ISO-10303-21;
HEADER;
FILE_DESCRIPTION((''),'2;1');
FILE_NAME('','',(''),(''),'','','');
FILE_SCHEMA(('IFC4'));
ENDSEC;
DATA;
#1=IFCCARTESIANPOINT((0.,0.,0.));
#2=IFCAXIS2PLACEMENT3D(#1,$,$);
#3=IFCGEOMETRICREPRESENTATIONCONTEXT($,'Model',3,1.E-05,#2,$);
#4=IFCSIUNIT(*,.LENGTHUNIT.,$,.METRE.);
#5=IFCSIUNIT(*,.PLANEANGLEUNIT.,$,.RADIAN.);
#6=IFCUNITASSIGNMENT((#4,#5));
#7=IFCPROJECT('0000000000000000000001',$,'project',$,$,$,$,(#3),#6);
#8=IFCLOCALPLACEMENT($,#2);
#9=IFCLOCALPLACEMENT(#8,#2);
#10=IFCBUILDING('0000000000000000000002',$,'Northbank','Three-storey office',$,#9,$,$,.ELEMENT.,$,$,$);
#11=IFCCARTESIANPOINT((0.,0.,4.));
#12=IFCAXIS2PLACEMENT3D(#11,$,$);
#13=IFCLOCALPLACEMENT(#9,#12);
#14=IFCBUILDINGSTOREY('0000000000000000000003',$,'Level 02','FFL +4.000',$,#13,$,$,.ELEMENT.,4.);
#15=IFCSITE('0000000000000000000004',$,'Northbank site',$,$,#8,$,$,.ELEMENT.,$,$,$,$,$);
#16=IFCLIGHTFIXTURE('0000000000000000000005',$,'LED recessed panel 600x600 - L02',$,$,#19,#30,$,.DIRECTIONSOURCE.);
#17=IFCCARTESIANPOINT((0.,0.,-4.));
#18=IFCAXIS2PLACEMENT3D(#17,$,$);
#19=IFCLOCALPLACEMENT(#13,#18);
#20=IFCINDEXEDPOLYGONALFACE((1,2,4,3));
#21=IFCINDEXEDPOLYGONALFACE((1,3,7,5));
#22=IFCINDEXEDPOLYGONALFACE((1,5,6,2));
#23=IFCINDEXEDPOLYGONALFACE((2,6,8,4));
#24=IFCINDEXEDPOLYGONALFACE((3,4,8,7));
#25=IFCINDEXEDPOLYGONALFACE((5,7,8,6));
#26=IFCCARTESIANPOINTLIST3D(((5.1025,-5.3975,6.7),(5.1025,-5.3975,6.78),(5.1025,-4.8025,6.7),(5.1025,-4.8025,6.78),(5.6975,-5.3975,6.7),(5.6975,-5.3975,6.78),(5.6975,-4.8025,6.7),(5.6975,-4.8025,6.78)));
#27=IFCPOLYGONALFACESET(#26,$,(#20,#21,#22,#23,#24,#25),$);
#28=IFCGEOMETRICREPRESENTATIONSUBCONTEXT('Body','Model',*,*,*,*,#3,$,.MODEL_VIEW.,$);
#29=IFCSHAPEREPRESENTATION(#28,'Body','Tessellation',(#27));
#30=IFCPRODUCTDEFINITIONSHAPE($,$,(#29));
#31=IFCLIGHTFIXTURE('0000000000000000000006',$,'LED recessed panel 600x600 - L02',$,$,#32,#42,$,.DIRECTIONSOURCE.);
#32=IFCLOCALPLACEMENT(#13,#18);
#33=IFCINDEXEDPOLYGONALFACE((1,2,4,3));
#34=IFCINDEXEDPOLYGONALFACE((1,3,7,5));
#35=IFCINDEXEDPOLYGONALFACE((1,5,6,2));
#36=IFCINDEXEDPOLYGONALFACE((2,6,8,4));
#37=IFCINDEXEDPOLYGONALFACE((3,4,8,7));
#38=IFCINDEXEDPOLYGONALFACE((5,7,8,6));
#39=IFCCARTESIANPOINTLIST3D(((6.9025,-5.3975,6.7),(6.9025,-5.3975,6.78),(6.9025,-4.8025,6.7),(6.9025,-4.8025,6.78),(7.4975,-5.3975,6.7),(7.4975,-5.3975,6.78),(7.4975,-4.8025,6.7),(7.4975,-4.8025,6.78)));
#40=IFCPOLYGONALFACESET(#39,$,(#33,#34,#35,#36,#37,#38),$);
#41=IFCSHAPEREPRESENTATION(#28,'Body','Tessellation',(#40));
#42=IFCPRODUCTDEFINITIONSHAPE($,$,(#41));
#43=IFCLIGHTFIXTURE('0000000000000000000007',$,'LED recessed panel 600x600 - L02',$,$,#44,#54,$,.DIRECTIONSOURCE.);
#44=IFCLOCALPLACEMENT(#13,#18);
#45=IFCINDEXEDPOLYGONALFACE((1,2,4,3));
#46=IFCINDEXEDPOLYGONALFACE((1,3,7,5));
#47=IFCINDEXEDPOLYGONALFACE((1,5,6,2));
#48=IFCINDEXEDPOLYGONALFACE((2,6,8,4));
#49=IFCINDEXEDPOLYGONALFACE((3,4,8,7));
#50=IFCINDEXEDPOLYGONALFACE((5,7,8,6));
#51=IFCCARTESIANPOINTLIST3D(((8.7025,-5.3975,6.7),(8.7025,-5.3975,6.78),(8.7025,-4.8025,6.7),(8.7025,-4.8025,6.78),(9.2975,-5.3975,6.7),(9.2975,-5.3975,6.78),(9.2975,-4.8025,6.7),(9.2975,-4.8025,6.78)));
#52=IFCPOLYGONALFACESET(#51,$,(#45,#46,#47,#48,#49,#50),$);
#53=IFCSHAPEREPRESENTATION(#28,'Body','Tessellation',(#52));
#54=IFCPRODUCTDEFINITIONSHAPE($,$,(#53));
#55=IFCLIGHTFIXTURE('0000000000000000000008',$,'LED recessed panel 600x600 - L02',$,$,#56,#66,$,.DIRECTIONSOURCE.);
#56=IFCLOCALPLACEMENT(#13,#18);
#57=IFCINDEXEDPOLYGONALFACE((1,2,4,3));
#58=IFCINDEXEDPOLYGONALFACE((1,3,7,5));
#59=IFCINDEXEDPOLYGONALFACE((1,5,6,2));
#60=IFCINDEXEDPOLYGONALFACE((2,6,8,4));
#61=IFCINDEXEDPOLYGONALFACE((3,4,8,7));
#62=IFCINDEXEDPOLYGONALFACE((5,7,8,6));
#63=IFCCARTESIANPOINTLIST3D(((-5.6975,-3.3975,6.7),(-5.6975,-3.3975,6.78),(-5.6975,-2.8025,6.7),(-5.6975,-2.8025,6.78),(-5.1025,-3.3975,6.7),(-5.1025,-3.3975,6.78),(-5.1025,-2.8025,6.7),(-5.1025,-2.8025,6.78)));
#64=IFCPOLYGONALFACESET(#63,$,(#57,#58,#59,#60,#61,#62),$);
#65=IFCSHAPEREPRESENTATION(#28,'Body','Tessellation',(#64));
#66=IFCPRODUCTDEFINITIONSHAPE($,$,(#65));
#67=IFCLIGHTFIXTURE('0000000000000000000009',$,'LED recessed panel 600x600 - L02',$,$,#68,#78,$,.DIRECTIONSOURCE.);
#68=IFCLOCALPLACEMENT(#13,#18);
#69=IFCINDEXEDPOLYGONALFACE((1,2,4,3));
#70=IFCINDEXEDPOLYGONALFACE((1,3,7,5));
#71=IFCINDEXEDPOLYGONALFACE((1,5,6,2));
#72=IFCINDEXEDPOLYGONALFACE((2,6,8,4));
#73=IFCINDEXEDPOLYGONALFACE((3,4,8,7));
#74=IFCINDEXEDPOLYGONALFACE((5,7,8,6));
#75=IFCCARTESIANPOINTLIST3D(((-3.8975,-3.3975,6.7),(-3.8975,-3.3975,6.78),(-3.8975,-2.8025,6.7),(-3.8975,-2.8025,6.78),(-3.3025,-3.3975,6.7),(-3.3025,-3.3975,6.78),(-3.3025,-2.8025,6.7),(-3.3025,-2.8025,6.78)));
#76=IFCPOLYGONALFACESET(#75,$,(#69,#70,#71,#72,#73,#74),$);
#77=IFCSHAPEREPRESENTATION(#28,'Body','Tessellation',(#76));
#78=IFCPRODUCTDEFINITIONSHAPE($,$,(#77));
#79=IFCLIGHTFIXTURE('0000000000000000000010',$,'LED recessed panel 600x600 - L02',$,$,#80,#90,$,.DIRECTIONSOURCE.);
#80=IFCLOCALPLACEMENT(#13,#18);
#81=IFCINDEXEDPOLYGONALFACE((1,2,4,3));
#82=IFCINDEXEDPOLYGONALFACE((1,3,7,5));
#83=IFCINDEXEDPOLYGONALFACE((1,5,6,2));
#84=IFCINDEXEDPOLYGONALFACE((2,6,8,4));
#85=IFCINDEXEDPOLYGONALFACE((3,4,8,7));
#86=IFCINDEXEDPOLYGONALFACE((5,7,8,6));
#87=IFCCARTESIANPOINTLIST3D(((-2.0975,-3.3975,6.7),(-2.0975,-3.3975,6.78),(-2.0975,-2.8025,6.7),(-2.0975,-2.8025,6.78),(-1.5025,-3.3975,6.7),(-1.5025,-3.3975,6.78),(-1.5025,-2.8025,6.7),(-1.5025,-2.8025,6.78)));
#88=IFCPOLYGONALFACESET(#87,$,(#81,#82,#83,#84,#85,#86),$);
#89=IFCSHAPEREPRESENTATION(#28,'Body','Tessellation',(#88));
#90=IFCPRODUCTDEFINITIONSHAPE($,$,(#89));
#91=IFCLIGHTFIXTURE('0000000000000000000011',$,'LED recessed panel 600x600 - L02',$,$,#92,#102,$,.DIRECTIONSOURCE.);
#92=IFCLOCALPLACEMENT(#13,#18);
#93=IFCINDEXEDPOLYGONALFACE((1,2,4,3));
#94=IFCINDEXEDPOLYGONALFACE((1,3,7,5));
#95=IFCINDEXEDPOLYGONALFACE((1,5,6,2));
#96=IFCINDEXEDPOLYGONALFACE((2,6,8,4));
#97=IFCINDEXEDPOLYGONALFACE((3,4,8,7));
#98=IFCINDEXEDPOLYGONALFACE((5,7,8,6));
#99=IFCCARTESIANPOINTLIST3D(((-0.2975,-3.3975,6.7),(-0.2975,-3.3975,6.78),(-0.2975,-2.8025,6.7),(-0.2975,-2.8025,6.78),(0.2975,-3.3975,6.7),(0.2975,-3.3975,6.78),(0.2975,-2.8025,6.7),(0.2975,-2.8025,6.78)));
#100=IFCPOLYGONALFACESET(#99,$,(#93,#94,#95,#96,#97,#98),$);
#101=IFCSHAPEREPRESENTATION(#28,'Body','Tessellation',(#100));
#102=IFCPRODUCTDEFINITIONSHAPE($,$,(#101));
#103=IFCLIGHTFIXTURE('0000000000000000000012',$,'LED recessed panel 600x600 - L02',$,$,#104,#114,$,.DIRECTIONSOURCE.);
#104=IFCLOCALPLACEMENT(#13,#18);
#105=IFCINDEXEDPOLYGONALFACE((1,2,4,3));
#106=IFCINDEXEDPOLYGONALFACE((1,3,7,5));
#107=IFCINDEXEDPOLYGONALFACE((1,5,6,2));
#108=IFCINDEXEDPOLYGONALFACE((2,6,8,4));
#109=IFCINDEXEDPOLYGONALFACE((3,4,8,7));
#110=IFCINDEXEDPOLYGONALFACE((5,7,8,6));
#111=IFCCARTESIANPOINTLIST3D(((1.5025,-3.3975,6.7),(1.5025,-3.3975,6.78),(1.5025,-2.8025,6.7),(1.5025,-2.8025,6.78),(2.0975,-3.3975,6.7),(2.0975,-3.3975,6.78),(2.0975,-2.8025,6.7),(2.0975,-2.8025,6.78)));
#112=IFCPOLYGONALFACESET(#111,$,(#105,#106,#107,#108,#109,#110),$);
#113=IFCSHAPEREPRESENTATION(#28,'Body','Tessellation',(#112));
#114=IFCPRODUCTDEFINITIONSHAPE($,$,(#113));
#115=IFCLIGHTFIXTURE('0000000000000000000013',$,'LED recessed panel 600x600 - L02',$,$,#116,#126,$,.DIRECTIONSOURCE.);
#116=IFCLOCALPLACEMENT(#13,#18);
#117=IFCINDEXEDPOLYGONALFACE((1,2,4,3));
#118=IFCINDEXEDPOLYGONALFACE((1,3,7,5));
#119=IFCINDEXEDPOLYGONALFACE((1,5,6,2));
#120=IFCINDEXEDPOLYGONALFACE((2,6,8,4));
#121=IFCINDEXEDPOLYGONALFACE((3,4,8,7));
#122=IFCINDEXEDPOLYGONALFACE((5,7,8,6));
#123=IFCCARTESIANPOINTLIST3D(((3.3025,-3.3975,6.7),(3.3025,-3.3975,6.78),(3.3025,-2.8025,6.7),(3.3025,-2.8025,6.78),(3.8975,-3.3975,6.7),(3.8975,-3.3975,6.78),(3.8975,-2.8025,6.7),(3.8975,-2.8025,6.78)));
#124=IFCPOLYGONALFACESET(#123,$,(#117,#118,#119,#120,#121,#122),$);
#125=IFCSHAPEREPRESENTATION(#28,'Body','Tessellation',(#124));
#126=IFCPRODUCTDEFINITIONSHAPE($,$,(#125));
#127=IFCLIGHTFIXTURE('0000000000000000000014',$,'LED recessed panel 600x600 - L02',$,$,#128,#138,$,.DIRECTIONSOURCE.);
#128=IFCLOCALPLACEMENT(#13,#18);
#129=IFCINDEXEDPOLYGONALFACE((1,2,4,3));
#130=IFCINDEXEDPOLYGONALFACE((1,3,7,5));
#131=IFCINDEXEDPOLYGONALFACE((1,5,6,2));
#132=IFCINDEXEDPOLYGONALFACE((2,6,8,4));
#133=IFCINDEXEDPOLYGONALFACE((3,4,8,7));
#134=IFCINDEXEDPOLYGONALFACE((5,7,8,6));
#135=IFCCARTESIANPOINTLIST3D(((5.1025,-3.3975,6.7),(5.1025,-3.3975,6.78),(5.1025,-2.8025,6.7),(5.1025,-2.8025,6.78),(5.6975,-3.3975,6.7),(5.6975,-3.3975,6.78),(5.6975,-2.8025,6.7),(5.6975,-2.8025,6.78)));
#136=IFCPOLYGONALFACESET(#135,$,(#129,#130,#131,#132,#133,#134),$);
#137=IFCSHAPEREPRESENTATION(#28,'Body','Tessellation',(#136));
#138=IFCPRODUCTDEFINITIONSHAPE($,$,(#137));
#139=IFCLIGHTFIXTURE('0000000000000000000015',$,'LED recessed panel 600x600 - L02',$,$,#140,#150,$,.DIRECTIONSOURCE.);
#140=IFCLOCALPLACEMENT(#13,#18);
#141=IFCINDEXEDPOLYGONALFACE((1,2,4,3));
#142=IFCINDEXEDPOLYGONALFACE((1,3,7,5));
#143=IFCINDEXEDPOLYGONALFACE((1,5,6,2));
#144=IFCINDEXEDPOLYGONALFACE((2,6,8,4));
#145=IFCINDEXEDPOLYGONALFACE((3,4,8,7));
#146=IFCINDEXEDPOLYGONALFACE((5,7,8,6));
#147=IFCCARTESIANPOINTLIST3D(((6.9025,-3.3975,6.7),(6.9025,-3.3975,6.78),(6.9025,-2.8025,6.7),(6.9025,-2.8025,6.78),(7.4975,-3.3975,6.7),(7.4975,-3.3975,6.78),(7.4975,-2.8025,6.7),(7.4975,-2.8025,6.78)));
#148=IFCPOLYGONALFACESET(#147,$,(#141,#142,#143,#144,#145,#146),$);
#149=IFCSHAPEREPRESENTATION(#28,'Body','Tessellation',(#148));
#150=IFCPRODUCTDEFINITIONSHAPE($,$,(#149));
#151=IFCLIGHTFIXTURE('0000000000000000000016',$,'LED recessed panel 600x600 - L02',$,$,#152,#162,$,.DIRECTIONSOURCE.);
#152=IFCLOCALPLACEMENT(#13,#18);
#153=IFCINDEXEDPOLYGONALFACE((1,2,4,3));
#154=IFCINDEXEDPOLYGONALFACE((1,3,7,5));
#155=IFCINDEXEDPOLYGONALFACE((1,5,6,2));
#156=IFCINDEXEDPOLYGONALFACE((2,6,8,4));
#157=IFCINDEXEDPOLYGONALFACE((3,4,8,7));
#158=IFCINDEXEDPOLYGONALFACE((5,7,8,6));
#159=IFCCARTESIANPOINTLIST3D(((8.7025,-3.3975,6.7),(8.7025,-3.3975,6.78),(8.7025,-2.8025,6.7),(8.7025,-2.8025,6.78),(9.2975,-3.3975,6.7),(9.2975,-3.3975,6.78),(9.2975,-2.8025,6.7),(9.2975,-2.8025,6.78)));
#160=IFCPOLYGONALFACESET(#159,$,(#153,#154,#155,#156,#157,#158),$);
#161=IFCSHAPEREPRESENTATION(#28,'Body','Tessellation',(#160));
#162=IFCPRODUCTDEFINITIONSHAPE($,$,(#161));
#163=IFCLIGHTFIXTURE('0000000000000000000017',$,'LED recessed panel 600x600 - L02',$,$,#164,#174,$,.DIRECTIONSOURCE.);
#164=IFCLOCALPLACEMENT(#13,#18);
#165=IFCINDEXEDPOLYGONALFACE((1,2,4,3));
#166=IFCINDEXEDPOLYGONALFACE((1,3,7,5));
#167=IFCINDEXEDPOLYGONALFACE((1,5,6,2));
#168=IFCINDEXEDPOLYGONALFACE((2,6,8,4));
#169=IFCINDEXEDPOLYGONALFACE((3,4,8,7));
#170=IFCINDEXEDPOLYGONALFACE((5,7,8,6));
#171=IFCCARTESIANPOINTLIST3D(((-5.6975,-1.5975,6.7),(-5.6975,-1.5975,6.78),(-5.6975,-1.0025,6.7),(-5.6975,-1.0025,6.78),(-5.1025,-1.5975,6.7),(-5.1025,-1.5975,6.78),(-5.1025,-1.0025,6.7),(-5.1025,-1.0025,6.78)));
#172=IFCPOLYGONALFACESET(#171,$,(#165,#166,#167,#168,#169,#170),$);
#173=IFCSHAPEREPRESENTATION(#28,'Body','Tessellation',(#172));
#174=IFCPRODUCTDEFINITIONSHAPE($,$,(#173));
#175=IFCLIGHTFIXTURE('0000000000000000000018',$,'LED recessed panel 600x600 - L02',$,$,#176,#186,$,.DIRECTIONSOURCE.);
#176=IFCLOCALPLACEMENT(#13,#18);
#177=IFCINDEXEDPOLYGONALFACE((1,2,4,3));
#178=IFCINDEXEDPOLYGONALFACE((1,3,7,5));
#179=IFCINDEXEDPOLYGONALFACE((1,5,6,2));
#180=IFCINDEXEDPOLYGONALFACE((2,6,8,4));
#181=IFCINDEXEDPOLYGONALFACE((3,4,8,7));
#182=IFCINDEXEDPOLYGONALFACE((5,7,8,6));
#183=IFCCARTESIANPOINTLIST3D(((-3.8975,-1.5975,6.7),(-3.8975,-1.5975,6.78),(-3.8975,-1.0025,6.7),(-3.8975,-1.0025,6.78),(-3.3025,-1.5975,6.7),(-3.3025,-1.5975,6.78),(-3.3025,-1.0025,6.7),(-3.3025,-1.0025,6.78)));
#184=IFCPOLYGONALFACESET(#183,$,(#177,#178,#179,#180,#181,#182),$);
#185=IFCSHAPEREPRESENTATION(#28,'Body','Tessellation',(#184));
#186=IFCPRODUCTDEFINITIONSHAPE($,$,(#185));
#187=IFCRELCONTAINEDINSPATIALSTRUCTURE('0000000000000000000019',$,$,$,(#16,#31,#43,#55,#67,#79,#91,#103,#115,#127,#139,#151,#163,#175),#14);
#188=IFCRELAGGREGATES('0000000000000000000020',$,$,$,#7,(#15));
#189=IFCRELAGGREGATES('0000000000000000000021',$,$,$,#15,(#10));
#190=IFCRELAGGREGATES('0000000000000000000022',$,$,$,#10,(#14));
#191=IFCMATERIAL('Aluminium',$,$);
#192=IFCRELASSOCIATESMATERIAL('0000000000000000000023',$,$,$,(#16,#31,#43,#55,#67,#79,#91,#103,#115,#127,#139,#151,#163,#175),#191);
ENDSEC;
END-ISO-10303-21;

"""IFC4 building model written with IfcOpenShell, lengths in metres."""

from ifc_helpers import new_model, si_unit, frame, origin, place, context, subcontext, project, spatial, rectangle, extrude, material, element, save


model = new_model("IFC4")

# Units and contexts
model_context = context("Model", 3, precision=1e-05, world=origin())
body_context = subcontext(model_context, "Body", "Model", "MODEL_VIEW")
ifc_project = project(units=[si_unit("LENGTHUNIT", "METRE"), si_unit("PLANEANGLEUNIT", "RADIAN")], contexts=[model_context])

# Site, building, storey
site_placement = place(None, origin())
site = spatial("IfcSite", under=ifc_project, at=site_placement, Name="Northbank site", CompositionType="ELEMENT")
building_placement = place(site_placement, origin())
building = spatial("IfcBuilding", under=site, at=building_placement, Name="Northbank", Description="Three-storey office", CompositionType="ELEMENT")
storey_placement = place(building_placement, frame((0.0, 0.0, 4.0)))
storey = spatial("IfcBuildingStorey", under=building, at=storey_placement, Name="Level 02", Description="FFL +4.000", CompositionType="ELEMENT", Elevation=4.0)

# Light fixtures
ifc_material = material(Name="Aluminium")
light_fixture_1_placement = place(storey_placement, frame((0.0, 0.0, -4.0)))
element("IfcLightFixture", 1, at=light_fixture_1_placement, inside=storey, material=ifc_material, Name="LED recessed panel 600x600 - L02", PredefinedType="DIRECTIONSOURCE", context=body_context, shape_type="SweptSolid", body=[
    extrude(rectangle(XDim=0.595, YDim=0.595), frame((5.4, -5.1, 6.7)), (0.0, 0.0, 1.0), 0.08),
])
light_fixture_2_placement = place(storey_placement, frame((0.0, 0.0, -4.0)))
element("IfcLightFixture", 2, at=light_fixture_2_placement, inside=storey, material=ifc_material, Name="LED recessed panel 600x600 - L02", PredefinedType="DIRECTIONSOURCE", context=body_context, shape_type="SweptSolid", body=[
    extrude(rectangle(XDim=0.595, YDim=0.595), frame((7.2, -5.1, 6.7)), (0.0, 0.0, 1.0), 0.08),
])
light_fixture_3_placement = place(storey_placement, frame((0.0, 0.0, -4.0)))
element("IfcLightFixture", 3, at=light_fixture_3_placement, inside=storey, material=ifc_material, Name="LED recessed panel 600x600 - L02", PredefinedType="DIRECTIONSOURCE", context=body_context, shape_type="SweptSolid", body=[
    extrude(rectangle(XDim=0.595, YDim=0.595), frame((9.0, -5.1, 6.7)), (0.0, 0.0, 1.0), 0.08),
])
light_fixture_4_placement = place(storey_placement, frame((0.0, 0.0, -4.0)))
element("IfcLightFixture", 4, at=light_fixture_4_placement, inside=storey, material=ifc_material, Name="LED recessed panel 600x600 - L02", PredefinedType="DIRECTIONSOURCE", context=body_context, shape_type="SweptSolid", body=[
    extrude(rectangle(XDim=0.595, YDim=0.595), frame((-5.4, -3.1, 6.7)), (0.0, 0.0, 1.0), 0.08),
])
light_fixture_5_placement = place(storey_placement, frame((0.0, 0.0, -4.0)))
element("IfcLightFixture", 5, at=light_fixture_5_placement, inside=storey, material=ifc_material, Name="LED recessed panel 600x600 - L02", PredefinedType="DIRECTIONSOURCE", context=body_context, shape_type="SweptSolid", body=[
    extrude(rectangle(XDim=0.595, YDim=0.595), frame((-3.6, -3.1, 6.7)), (0.0, 0.0, 1.0), 0.08),
])
light_fixture_6_placement = place(storey_placement, frame((0.0, 0.0, -4.0)))
element("IfcLightFixture", 6, at=light_fixture_6_placement, inside=storey, material=ifc_material, Name="LED recessed panel 600x600 - L02", PredefinedType="DIRECTIONSOURCE", context=body_context, shape_type="SweptSolid", body=[
    extrude(rectangle(XDim=0.595, YDim=0.595), frame((-1.8, -3.1, 6.7)), (0.0, 0.0, 1.0), 0.08),
])
light_fixture_7_placement = place(storey_placement, frame((0.0, 0.0, -4.0)))
element("IfcLightFixture", 7, at=light_fixture_7_placement, inside=storey, material=ifc_material, Name="LED recessed panel 600x600 - L02", PredefinedType="DIRECTIONSOURCE", context=body_context, shape_type="SweptSolid", body=[
    extrude(rectangle(XDim=0.595, YDim=0.595), frame((0.0, -3.1, 6.7)), (0.0, 0.0, 1.0), 0.08),
])
light_fixture_8_placement = place(storey_placement, frame((0.0, 0.0, -4.0)))
element("IfcLightFixture", 8, at=light_fixture_8_placement, inside=storey, material=ifc_material, Name="LED recessed panel 600x600 - L02", PredefinedType="DIRECTIONSOURCE", context=body_context, shape_type="SweptSolid", body=[
    extrude(rectangle(XDim=0.595, YDim=0.595), frame((1.8, -3.1, 6.7)), (0.0, 0.0, 1.0), 0.08),
])
light_fixture_9_placement = place(storey_placement, frame((0.0, 0.0, -4.0)))
element("IfcLightFixture", 9, at=light_fixture_9_placement, inside=storey, material=ifc_material, Name="LED recessed panel 600x600 - L02", PredefinedType="DIRECTIONSOURCE", context=body_context, shape_type="SweptSolid", body=[
    extrude(rectangle(XDim=0.595, YDim=0.595), frame((3.6, -3.1, 6.7)), (0.0, 0.0, 1.0), 0.08),
])
light_fixture_10_placement = place(storey_placement, frame((0.0, 0.0, -4.0)))
element("IfcLightFixture", 10, at=light_fixture_10_placement, inside=storey, material=ifc_material, Name="LED recessed panel 600x600 - L02", PredefinedType="DIRECTIONSOURCE", context=body_context, shape_type="SweptSolid", body=[
    extrude(rectangle(XDim=0.595, YDim=0.595), frame((5.4, -3.1, 6.7)), (0.0, 0.0, 1.0), 0.08),
])
light_fixture_11_placement = place(storey_placement, frame((0.0, 0.0, -4.0)))
element("IfcLightFixture", 11, at=light_fixture_11_placement, inside=storey, material=ifc_material, Name="LED recessed panel 600x600 - L02", PredefinedType="DIRECTIONSOURCE", context=body_context, shape_type="SweptSolid", body=[
    extrude(rectangle(XDim=0.595, YDim=0.595), frame((7.2, -3.1, 6.7)), (0.0, 0.0, 1.0), 0.08),
])
light_fixture_12_placement = place(storey_placement, frame((0.0, 0.0, -4.0)))
element("IfcLightFixture", 12, at=light_fixture_12_placement, inside=storey, material=ifc_material, Name="LED recessed panel 600x600 - L02", PredefinedType="DIRECTIONSOURCE", context=body_context, shape_type="SweptSolid", body=[
    extrude(rectangle(XDim=0.595, YDim=0.595), frame((9.0, -3.1, 6.7)), (0.0, 0.0, 1.0), 0.08),
])
light_fixture_13_placement = place(storey_placement, frame((0.0, 0.0, -4.0)))
element("IfcLightFixture", 13, at=light_fixture_13_placement, inside=storey, material=ifc_material, Name="LED recessed panel 600x600 - L02", PredefinedType="DIRECTIONSOURCE", context=body_context, shape_type="SweptSolid", body=[
    extrude(rectangle(XDim=0.595, YDim=0.595), frame((-5.4, -1.3, 6.7)), (0.0, 0.0, 1.0), 0.08),
])
light_fixture_14_placement = place(storey_placement, frame((0.0, 0.0, -4.0)))
element("IfcLightFixture", 14, at=light_fixture_14_placement, inside=storey, material=ifc_material, Name="LED recessed panel 600x600 - L02", PredefinedType="DIRECTIONSOURCE", context=body_context, shape_type="SweptSolid", body=[
    extrude(rectangle(XDim=0.595, YDim=0.595), frame((-3.6, -1.3, 6.7)), (0.0, 0.0, 1.0), 0.08),
])

save(model, "model.ifc")
